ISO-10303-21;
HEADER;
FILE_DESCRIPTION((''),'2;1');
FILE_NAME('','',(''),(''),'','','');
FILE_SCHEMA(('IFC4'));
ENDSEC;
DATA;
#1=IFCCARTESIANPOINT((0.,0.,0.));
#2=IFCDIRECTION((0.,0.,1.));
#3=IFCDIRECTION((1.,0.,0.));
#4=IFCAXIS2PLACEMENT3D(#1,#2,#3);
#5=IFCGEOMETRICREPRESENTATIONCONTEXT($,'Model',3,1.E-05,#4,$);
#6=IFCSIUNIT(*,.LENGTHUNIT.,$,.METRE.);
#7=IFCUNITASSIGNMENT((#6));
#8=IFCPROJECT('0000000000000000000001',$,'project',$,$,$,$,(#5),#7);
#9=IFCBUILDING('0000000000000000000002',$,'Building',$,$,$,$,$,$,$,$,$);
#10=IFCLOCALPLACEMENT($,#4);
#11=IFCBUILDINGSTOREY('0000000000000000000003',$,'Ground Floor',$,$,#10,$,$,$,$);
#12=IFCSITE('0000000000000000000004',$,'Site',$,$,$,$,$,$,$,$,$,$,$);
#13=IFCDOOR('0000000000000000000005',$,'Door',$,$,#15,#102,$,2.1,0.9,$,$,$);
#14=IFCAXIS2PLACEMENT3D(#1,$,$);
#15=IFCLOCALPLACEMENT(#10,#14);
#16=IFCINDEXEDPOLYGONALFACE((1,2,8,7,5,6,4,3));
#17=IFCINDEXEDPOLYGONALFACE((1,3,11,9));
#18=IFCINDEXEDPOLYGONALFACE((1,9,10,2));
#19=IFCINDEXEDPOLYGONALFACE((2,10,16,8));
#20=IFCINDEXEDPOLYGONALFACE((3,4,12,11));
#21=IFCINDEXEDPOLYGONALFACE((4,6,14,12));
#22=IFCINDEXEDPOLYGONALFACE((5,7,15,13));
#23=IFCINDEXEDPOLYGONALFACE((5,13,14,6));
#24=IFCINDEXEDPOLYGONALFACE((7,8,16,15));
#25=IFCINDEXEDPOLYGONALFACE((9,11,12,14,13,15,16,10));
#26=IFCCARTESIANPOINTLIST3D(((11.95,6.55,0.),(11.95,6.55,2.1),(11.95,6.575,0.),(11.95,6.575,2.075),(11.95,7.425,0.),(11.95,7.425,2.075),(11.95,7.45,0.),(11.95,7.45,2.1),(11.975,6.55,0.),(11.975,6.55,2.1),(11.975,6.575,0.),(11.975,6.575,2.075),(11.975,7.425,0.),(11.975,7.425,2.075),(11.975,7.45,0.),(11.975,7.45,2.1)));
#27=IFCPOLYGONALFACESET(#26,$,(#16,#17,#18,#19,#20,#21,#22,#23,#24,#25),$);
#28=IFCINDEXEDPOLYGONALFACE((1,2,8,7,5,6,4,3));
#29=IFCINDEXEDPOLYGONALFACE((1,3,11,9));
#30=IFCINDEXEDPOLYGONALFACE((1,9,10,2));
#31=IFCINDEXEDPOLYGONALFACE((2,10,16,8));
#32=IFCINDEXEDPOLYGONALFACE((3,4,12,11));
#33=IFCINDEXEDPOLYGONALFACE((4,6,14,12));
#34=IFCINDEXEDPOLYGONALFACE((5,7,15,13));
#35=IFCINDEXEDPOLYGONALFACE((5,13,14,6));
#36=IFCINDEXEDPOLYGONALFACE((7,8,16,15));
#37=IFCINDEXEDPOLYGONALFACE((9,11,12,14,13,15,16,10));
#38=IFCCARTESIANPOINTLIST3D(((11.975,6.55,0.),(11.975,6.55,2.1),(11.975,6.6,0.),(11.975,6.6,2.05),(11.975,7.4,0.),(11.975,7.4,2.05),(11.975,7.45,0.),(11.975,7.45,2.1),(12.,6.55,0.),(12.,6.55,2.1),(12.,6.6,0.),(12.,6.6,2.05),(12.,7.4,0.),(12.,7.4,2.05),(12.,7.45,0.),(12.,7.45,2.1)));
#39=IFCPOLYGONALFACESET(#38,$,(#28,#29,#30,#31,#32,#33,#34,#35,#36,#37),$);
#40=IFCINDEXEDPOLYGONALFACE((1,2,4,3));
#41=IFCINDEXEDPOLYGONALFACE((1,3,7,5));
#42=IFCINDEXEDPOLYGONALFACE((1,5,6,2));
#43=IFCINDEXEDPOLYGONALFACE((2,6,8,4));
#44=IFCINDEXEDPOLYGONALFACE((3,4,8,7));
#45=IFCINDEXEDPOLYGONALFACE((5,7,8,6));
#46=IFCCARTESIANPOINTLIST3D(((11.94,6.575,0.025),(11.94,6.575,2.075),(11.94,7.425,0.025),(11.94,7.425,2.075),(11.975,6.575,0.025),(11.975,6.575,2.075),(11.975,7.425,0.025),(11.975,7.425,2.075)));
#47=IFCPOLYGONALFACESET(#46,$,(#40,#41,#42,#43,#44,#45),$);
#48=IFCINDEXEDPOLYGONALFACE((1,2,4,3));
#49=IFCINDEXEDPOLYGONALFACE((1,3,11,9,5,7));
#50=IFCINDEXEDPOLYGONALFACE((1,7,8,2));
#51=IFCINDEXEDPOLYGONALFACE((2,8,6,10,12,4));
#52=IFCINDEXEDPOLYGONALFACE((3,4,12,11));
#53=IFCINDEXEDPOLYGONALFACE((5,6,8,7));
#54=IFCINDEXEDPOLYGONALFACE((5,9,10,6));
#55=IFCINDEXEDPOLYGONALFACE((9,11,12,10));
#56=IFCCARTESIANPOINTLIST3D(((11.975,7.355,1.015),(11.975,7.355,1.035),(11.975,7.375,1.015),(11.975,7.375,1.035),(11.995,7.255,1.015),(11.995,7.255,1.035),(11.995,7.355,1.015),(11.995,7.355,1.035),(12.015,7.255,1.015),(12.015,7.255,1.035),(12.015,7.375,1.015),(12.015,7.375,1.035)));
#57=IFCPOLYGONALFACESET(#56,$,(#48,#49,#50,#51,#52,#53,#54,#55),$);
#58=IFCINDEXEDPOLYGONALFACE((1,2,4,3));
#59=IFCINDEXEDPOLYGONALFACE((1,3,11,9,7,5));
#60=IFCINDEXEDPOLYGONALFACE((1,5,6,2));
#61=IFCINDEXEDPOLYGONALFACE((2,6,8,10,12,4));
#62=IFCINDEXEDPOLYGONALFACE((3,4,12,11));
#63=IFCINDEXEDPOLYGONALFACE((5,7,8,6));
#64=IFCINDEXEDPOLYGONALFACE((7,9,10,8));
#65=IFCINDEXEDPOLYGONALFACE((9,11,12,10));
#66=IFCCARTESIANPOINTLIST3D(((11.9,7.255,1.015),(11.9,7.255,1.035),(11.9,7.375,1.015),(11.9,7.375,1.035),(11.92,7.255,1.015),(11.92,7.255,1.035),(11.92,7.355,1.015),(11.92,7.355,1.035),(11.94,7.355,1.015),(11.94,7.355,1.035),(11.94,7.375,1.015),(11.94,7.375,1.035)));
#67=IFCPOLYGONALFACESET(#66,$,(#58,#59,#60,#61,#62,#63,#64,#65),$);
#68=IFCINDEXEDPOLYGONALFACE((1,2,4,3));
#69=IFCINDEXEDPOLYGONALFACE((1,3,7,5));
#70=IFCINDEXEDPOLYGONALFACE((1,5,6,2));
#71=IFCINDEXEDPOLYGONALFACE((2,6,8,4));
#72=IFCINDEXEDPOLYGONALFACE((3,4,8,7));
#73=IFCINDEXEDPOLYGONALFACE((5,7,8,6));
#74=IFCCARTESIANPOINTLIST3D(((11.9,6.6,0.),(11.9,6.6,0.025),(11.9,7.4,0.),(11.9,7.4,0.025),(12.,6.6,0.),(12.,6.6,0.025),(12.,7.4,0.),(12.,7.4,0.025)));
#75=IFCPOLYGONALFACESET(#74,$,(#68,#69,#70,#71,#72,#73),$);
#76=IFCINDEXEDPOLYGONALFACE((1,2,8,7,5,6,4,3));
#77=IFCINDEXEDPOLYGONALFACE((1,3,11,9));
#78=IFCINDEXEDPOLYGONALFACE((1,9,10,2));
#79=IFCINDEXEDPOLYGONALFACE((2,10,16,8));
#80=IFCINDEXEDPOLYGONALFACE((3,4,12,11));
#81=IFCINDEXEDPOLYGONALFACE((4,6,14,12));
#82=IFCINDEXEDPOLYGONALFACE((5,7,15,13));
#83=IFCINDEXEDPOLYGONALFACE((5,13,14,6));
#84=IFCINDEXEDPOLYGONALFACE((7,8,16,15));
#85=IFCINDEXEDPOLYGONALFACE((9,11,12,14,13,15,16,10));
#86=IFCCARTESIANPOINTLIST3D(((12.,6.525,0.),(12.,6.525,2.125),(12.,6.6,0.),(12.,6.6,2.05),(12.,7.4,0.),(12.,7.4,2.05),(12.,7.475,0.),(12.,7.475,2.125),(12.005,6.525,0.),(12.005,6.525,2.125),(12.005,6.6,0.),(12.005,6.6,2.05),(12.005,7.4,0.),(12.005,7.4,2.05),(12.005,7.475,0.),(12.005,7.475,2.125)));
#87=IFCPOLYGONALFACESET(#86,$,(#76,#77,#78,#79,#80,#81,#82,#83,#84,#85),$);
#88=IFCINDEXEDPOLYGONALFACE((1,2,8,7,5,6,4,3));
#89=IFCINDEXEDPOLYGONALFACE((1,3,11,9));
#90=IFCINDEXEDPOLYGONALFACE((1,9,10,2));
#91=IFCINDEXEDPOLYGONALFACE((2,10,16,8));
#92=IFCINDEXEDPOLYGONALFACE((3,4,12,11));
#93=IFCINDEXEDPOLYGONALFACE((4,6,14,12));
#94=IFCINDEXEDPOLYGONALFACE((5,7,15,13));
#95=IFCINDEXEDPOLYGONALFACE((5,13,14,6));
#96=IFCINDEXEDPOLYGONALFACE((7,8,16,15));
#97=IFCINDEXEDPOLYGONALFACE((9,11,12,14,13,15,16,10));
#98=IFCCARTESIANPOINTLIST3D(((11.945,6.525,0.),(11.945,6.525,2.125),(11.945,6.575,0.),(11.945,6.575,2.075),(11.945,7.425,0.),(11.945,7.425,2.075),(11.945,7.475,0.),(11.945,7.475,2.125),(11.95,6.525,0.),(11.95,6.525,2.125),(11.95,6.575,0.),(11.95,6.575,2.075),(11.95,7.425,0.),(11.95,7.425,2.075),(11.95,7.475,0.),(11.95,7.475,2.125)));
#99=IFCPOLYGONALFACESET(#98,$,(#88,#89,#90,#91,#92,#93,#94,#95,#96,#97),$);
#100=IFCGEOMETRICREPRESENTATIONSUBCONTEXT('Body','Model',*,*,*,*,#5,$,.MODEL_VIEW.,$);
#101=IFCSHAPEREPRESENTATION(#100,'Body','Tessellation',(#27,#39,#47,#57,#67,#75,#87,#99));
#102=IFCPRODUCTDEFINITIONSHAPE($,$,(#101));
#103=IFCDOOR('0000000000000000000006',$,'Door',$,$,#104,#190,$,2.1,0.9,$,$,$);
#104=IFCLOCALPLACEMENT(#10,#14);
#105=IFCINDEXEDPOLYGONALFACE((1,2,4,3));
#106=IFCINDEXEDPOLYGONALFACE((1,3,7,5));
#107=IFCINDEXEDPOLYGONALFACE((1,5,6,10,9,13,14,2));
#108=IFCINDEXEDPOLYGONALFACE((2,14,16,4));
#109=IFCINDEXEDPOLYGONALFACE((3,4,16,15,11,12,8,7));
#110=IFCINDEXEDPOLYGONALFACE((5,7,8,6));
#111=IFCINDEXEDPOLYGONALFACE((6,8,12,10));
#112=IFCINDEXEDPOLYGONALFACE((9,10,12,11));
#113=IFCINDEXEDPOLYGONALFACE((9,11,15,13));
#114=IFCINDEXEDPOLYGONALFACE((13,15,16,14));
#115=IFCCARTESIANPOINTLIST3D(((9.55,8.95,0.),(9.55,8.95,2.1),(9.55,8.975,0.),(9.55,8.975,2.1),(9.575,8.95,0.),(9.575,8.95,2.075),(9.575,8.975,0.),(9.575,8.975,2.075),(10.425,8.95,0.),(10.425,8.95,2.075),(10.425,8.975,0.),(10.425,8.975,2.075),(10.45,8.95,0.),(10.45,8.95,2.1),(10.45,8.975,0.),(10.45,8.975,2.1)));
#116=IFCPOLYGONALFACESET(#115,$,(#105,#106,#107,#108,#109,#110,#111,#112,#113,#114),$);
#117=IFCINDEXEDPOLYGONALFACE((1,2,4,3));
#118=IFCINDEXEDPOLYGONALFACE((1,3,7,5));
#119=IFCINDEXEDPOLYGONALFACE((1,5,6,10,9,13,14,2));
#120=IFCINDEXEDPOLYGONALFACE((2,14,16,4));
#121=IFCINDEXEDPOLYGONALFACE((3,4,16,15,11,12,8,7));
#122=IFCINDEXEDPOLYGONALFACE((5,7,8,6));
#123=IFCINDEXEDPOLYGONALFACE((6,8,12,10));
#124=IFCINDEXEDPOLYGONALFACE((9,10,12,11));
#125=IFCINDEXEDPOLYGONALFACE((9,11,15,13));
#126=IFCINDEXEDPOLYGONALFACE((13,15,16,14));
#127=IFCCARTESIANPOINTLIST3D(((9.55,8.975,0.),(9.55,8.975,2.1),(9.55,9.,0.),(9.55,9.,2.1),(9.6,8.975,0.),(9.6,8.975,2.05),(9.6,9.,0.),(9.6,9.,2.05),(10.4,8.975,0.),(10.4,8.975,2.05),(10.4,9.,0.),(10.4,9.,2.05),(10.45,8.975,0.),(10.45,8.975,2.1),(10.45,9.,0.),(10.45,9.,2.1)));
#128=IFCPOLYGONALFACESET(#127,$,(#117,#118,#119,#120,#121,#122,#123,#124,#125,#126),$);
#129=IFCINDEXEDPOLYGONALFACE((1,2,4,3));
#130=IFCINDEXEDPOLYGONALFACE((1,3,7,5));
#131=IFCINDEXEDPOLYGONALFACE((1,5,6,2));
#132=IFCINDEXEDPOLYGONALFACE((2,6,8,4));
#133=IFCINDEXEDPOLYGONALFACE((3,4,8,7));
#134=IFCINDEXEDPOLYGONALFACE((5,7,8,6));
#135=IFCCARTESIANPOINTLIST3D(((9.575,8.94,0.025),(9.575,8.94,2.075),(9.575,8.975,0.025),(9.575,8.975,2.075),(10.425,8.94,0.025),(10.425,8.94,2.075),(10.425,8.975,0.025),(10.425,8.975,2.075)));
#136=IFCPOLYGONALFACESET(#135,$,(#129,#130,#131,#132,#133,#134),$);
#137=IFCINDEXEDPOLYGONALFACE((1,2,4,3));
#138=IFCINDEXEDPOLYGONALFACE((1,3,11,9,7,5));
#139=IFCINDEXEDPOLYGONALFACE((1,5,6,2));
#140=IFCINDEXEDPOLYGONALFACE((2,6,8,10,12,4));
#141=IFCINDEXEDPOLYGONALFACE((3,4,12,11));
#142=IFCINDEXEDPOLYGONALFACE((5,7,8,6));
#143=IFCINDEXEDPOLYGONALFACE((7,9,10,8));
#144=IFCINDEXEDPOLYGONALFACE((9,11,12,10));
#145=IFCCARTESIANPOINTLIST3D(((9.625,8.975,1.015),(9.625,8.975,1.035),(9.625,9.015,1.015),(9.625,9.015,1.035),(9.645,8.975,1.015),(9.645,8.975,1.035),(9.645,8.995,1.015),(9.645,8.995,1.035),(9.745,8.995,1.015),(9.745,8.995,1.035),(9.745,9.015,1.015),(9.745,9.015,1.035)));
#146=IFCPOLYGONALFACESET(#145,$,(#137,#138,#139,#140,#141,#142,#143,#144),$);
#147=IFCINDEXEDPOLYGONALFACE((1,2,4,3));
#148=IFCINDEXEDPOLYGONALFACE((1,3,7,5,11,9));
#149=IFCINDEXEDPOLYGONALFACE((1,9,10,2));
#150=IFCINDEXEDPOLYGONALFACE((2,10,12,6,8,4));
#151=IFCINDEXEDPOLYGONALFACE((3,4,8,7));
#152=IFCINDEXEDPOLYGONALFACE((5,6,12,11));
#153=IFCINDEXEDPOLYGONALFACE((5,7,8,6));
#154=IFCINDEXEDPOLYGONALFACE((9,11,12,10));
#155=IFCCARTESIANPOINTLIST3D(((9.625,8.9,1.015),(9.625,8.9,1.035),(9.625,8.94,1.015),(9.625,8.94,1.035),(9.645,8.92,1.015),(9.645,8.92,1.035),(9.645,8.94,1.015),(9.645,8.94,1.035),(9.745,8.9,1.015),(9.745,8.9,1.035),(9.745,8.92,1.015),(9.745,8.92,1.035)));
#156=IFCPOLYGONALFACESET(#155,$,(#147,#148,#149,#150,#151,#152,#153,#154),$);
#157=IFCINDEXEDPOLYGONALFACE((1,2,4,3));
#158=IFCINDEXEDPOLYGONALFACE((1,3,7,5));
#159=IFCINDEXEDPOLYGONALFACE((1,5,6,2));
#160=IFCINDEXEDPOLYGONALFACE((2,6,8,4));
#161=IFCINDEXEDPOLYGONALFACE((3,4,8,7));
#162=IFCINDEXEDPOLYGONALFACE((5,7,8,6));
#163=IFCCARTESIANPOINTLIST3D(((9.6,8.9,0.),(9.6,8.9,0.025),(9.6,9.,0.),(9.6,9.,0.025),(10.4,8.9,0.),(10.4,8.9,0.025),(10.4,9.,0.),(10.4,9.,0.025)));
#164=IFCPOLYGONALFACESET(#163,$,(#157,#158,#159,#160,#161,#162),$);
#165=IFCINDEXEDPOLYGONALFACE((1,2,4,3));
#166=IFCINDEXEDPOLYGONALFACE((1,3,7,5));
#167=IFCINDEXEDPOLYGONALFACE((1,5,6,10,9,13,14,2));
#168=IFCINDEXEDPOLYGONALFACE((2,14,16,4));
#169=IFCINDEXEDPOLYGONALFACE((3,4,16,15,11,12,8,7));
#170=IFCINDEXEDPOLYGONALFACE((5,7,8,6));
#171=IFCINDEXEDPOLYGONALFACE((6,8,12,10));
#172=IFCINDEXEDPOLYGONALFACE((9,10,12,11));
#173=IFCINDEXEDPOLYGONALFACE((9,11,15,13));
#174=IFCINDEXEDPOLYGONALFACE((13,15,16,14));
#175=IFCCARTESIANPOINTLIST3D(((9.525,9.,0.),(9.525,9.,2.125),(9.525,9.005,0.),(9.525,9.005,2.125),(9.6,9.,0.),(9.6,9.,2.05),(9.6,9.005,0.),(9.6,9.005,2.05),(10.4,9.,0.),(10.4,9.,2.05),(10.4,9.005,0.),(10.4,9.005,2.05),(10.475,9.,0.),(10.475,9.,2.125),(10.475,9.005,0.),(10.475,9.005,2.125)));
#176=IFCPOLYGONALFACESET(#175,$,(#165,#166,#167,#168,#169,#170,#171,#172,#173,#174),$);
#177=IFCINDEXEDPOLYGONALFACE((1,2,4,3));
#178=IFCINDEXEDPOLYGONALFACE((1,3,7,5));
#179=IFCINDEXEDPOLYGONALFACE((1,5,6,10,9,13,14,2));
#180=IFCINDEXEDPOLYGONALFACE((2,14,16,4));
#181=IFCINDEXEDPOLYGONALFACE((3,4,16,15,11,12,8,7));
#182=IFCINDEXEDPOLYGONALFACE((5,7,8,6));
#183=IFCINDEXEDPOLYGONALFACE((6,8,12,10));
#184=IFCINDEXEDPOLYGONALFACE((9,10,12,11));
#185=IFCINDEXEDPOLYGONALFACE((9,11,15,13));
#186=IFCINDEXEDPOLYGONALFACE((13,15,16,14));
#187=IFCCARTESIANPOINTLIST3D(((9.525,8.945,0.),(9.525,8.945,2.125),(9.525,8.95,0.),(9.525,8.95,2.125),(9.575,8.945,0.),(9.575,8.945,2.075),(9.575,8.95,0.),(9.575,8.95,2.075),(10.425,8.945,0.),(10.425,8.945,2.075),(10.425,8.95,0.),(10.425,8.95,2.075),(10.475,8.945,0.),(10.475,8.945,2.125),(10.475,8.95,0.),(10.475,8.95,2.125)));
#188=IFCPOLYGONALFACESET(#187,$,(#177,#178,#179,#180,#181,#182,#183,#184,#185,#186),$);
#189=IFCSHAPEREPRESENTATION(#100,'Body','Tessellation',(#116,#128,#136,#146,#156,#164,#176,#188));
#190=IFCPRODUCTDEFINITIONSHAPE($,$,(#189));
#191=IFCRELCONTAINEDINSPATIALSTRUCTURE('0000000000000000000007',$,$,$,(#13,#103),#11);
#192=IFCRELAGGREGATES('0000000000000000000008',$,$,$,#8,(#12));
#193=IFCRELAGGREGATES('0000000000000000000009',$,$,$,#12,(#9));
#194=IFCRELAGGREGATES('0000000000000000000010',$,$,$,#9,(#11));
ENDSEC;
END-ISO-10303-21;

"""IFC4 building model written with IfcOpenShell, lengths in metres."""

from ifc_helpers import new_model, si_unit, frame, origin_with_axes, place, context, subcontext, project, spatial, line, indexed_curve, outline, extrude, element, save


model = new_model("IFC4")

# Units and contexts
model_context = context("Model", 3, precision=1e-05, world=origin_with_axes())
body_context = subcontext(model_context, "Body", "Model", "MODEL_VIEW")
ifc_project = project(units=[si_unit("LENGTHUNIT", "METRE")], contexts=[model_context])

# Site, building, storey
site = spatial("IfcSite", under=ifc_project, Name="Site")
building = spatial("IfcBuilding", under=site, Name="Building")
storey_placement = place(None, origin_with_axes())
storey = spatial("IfcBuildingStorey", under=building, at=storey_placement, Name="Ground Floor")

# Doors
door_1_placement = place(storey_placement, frame((12.0, 6.55, 0.0), z_axis=(0.0, 0.0, 1.0), x_axis=(0.0, 1.0, 0.0)))
element("IfcDoor", 1, at=door_1_placement, inside=storey, Name="Door", OverallHeight=2.1, OverallWidth=0.9, context=body_context, shape_type="SweptSolid", body=[
    extrude(outline(indexed_curve([(0.0, 0.0), (0.0, 2.1), (0.9, 2.1), (0.9, 0.0), (0.875, 0.0), (0.875, 2.075), (0.025, 2.075), (0.025, 0.0)], segments=[line(1, 2, 3, 4, 5, 6, 7, 8, 1)])), frame((0.0, 0.025, 0.0), z_axis=(0.0, -1.0, 0.0), x_axis=(1.0, 0.0, 0.0)), (0.0, 0.0, -1.0), 0.025),
    extrude(outline(indexed_curve([(0.0, 0.0), (0.0, 2.1), (0.9, 2.1), (0.9, 0.0), (0.85, 0.0), (0.85, 2.05), (0.05, 2.05), (0.05, 0.0)], segments=[line(1, 2, 3, 4, 5, 6, 7, 8, 1)])), frame((0.0, 0.0, 0.0), z_axis=(0.0, -1.0, 0.0), x_axis=(1.0, 0.0, 0.0)), (0.0, 0.0, -1.0), 0.025),
    extrude(outline(indexed_curve([(0.0, 0.0), (0.85, 0.0), (0.85, 0.035), (0.0, 0.035)], segments=[line(1, 2, 3, 4, 1)])), frame((0.025, 0.025, 0.025), z_axis=(0.0, 0.0, 1.0), x_axis=(1.0, 0.0, 0.0)), (0.0, 0.0, 1.0), 2.05),
    extrude(outline(indexed_curve([(0.0, 0.0), (0.0, -0.04), (-0.12, -0.04), (-0.12, -0.02), (-0.02, -0.02), (-0.02, 0.0)], segments=[line(1, 2, 3, 4, 5, 6, 1)])), frame((0.825, 0.025, 1.015), z_axis=(0.0, 0.0, 1.0), x_axis=(1.0, 0.0, 0.0)), (0.0, 0.0, 1.0), 0.02),
    extrude(outline(indexed_curve([(0.0, 0.0), (0.0, 0.04), (-0.12, 0.04), (-0.12, 0.02), (-0.02, 0.02), (-0.02, 0.0)], segments=[line(1, 2, 3, 4, 5, 6, 1)])), frame((0.825, 0.06, 1.015), z_axis=(0.0, 0.0, 1.0), x_axis=(1.0, 0.0, 0.0)), (0.0, 0.0, 1.0), 0.02),
    extrude(outline(indexed_curve([(0.0, 0.0), (0.8, 0.0), (0.8, 0.1), (0.0, 0.1)], segments=[line(1, 2, 3, 4, 1)])), frame((0.05, 0.0, 0.0), z_axis=(0.0, 0.0, 1.0), x_axis=(1.0, 0.0, 0.0)), (0.0, 0.0, 1.0), 0.025),
    extrude(outline(indexed_curve([(0.0, 0.0), (0.0, 2.125), (0.95, 2.125), (0.95, 0.0), (0.875, 0.0), (0.875, 2.05), (0.075, 2.05), (0.075, 0.0)], segments=[line(1, 2, 3, 4, 5, 6, 7, 8, 1)])), frame((-0.025, -0.005, 0.0), z_axis=(0.0, -1.0, 0.0), x_axis=(1.0, 0.0, 0.0)), (0.0, 0.0, -1.0), 0.005),
    extrude(outline(indexed_curve([(0.0, 0.0), (0.0, 2.125), (0.95, 2.125), (0.95, 0.0), (0.9, 0.0), (0.9, 2.075), (0.05, 2.075), (0.05, 0.0)], segments=[line(1, 2, 3, 4, 5, 6, 7, 8, 1)])), frame((-0.025, 0.05, 0.0), z_axis=(0.0, -1.0, 0.0), x_axis=(1.0, 0.0, 0.0)), (0.0, 0.0, -1.0), 0.005),
])
door_2_placement = place(storey_placement, frame((10.45, 9.0, 0.0), z_axis=(0.0, 0.0, 1.0), x_axis=(-1.0, 0.0, 0.0)))
element("IfcDoor", 2, at=door_2_placement, inside=storey, Name="Door", OverallHeight=2.1, OverallWidth=0.9, context=body_context, shape_type="SweptSolid", body=[
    extrude(outline(indexed_curve([(0.0, 0.0), (0.0, 2.1), (0.9, 2.1), (0.9, 0.0), (0.875, 0.0), (0.875, 2.075), (0.025, 2.075), (0.025, 0.0)], segments=[line(1, 2, 3, 4, 5, 6, 7, 8, 1)])), frame((0.0, 0.025, 0.0), z_axis=(0.0, -1.0, 0.0), x_axis=(1.0, 0.0, 0.0)), (0.0, 0.0, -1.0), 0.025),
    extrude(outline(indexed_curve([(0.0, 0.0), (0.0, 2.1), (0.9, 2.1), (0.9, 0.0), (0.85, 0.0), (0.85, 2.05), (0.05, 2.05), (0.05, 0.0)], segments=[line(1, 2, 3, 4, 5, 6, 7, 8, 1)])), frame((0.0, 0.0, 0.0), z_axis=(0.0, -1.0, 0.0), x_axis=(1.0, 0.0, 0.0)), (0.0, 0.0, -1.0), 0.025),
    extrude(outline(indexed_curve([(0.0, 0.0), (0.85, 0.0), (0.85, 0.035), (0.0, 0.035)], segments=[line(1, 2, 3, 4, 1)])), frame((0.025, 0.025, 0.025), z_axis=(0.0, 0.0, 1.0), x_axis=(1.0, 0.0, 0.0)), (0.0, 0.0, 1.0), 2.05),
    extrude(outline(indexed_curve([(0.0, 0.0), (0.0, -0.04), (-0.12, -0.04), (-0.12, -0.02), (-0.02, -0.02), (-0.02, 0.0)], segments=[line(1, 2, 3, 4, 5, 6, 1)])), frame((0.825, 0.025, 1.015), z_axis=(0.0, 0.0, 1.0), x_axis=(1.0, 0.0, 0.0)), (0.0, 0.0, 1.0), 0.02),
    extrude(outline(indexed_curve([(0.0, 0.0), (0.0, 0.04), (-0.12, 0.04), (-0.12, 0.02), (-0.02, 0.02), (-0.02, 0.0)], segments=[line(1, 2, 3, 4, 5, 6, 1)])), frame((0.825, 0.06, 1.015), z_axis=(0.0, 0.0, 1.0), x_axis=(1.0, 0.0, 0.0)), (0.0, 0.0, 1.0), 0.02),
    extrude(outline(indexed_curve([(0.0, 0.0), (0.8, 0.0), (0.8, 0.1), (0.0, 0.1)], segments=[line(1, 2, 3, 4, 1)])), frame((0.05, 0.0, 0.0), z_axis=(0.0, 0.0, 1.0), x_axis=(1.0, 0.0, 0.0)), (0.0, 0.0, 1.0), 0.025),
    extrude(outline(indexed_curve([(0.0, 0.0), (0.0, 2.125), (0.95, 2.125), (0.95, 0.0), (0.875, 0.0), (0.875, 2.05), (0.075, 2.05), (0.075, 0.0)], segments=[line(1, 2, 3, 4, 5, 6, 7, 8, 1)])), frame((-0.025, -0.005, 0.0), z_axis=(0.0, -1.0, 0.0), x_axis=(1.0, 0.0, 0.0)), (0.0, 0.0, -1.0), 0.005),
    extrude(outline(indexed_curve([(0.0, 0.0), (0.0, 2.125), (0.95, 2.125), (0.95, 0.0), (0.9, 0.0), (0.9, 2.075), (0.05, 2.075), (0.05, 0.0)], segments=[line(1, 2, 3, 4, 5, 6, 7, 8, 1)])), frame((-0.025, 0.05, 0.0), z_axis=(0.0, -1.0, 0.0), x_axis=(1.0, 0.0, 0.0)), (0.0, 0.0, -1.0), 0.005),
])

save(model, "model.ifc")
